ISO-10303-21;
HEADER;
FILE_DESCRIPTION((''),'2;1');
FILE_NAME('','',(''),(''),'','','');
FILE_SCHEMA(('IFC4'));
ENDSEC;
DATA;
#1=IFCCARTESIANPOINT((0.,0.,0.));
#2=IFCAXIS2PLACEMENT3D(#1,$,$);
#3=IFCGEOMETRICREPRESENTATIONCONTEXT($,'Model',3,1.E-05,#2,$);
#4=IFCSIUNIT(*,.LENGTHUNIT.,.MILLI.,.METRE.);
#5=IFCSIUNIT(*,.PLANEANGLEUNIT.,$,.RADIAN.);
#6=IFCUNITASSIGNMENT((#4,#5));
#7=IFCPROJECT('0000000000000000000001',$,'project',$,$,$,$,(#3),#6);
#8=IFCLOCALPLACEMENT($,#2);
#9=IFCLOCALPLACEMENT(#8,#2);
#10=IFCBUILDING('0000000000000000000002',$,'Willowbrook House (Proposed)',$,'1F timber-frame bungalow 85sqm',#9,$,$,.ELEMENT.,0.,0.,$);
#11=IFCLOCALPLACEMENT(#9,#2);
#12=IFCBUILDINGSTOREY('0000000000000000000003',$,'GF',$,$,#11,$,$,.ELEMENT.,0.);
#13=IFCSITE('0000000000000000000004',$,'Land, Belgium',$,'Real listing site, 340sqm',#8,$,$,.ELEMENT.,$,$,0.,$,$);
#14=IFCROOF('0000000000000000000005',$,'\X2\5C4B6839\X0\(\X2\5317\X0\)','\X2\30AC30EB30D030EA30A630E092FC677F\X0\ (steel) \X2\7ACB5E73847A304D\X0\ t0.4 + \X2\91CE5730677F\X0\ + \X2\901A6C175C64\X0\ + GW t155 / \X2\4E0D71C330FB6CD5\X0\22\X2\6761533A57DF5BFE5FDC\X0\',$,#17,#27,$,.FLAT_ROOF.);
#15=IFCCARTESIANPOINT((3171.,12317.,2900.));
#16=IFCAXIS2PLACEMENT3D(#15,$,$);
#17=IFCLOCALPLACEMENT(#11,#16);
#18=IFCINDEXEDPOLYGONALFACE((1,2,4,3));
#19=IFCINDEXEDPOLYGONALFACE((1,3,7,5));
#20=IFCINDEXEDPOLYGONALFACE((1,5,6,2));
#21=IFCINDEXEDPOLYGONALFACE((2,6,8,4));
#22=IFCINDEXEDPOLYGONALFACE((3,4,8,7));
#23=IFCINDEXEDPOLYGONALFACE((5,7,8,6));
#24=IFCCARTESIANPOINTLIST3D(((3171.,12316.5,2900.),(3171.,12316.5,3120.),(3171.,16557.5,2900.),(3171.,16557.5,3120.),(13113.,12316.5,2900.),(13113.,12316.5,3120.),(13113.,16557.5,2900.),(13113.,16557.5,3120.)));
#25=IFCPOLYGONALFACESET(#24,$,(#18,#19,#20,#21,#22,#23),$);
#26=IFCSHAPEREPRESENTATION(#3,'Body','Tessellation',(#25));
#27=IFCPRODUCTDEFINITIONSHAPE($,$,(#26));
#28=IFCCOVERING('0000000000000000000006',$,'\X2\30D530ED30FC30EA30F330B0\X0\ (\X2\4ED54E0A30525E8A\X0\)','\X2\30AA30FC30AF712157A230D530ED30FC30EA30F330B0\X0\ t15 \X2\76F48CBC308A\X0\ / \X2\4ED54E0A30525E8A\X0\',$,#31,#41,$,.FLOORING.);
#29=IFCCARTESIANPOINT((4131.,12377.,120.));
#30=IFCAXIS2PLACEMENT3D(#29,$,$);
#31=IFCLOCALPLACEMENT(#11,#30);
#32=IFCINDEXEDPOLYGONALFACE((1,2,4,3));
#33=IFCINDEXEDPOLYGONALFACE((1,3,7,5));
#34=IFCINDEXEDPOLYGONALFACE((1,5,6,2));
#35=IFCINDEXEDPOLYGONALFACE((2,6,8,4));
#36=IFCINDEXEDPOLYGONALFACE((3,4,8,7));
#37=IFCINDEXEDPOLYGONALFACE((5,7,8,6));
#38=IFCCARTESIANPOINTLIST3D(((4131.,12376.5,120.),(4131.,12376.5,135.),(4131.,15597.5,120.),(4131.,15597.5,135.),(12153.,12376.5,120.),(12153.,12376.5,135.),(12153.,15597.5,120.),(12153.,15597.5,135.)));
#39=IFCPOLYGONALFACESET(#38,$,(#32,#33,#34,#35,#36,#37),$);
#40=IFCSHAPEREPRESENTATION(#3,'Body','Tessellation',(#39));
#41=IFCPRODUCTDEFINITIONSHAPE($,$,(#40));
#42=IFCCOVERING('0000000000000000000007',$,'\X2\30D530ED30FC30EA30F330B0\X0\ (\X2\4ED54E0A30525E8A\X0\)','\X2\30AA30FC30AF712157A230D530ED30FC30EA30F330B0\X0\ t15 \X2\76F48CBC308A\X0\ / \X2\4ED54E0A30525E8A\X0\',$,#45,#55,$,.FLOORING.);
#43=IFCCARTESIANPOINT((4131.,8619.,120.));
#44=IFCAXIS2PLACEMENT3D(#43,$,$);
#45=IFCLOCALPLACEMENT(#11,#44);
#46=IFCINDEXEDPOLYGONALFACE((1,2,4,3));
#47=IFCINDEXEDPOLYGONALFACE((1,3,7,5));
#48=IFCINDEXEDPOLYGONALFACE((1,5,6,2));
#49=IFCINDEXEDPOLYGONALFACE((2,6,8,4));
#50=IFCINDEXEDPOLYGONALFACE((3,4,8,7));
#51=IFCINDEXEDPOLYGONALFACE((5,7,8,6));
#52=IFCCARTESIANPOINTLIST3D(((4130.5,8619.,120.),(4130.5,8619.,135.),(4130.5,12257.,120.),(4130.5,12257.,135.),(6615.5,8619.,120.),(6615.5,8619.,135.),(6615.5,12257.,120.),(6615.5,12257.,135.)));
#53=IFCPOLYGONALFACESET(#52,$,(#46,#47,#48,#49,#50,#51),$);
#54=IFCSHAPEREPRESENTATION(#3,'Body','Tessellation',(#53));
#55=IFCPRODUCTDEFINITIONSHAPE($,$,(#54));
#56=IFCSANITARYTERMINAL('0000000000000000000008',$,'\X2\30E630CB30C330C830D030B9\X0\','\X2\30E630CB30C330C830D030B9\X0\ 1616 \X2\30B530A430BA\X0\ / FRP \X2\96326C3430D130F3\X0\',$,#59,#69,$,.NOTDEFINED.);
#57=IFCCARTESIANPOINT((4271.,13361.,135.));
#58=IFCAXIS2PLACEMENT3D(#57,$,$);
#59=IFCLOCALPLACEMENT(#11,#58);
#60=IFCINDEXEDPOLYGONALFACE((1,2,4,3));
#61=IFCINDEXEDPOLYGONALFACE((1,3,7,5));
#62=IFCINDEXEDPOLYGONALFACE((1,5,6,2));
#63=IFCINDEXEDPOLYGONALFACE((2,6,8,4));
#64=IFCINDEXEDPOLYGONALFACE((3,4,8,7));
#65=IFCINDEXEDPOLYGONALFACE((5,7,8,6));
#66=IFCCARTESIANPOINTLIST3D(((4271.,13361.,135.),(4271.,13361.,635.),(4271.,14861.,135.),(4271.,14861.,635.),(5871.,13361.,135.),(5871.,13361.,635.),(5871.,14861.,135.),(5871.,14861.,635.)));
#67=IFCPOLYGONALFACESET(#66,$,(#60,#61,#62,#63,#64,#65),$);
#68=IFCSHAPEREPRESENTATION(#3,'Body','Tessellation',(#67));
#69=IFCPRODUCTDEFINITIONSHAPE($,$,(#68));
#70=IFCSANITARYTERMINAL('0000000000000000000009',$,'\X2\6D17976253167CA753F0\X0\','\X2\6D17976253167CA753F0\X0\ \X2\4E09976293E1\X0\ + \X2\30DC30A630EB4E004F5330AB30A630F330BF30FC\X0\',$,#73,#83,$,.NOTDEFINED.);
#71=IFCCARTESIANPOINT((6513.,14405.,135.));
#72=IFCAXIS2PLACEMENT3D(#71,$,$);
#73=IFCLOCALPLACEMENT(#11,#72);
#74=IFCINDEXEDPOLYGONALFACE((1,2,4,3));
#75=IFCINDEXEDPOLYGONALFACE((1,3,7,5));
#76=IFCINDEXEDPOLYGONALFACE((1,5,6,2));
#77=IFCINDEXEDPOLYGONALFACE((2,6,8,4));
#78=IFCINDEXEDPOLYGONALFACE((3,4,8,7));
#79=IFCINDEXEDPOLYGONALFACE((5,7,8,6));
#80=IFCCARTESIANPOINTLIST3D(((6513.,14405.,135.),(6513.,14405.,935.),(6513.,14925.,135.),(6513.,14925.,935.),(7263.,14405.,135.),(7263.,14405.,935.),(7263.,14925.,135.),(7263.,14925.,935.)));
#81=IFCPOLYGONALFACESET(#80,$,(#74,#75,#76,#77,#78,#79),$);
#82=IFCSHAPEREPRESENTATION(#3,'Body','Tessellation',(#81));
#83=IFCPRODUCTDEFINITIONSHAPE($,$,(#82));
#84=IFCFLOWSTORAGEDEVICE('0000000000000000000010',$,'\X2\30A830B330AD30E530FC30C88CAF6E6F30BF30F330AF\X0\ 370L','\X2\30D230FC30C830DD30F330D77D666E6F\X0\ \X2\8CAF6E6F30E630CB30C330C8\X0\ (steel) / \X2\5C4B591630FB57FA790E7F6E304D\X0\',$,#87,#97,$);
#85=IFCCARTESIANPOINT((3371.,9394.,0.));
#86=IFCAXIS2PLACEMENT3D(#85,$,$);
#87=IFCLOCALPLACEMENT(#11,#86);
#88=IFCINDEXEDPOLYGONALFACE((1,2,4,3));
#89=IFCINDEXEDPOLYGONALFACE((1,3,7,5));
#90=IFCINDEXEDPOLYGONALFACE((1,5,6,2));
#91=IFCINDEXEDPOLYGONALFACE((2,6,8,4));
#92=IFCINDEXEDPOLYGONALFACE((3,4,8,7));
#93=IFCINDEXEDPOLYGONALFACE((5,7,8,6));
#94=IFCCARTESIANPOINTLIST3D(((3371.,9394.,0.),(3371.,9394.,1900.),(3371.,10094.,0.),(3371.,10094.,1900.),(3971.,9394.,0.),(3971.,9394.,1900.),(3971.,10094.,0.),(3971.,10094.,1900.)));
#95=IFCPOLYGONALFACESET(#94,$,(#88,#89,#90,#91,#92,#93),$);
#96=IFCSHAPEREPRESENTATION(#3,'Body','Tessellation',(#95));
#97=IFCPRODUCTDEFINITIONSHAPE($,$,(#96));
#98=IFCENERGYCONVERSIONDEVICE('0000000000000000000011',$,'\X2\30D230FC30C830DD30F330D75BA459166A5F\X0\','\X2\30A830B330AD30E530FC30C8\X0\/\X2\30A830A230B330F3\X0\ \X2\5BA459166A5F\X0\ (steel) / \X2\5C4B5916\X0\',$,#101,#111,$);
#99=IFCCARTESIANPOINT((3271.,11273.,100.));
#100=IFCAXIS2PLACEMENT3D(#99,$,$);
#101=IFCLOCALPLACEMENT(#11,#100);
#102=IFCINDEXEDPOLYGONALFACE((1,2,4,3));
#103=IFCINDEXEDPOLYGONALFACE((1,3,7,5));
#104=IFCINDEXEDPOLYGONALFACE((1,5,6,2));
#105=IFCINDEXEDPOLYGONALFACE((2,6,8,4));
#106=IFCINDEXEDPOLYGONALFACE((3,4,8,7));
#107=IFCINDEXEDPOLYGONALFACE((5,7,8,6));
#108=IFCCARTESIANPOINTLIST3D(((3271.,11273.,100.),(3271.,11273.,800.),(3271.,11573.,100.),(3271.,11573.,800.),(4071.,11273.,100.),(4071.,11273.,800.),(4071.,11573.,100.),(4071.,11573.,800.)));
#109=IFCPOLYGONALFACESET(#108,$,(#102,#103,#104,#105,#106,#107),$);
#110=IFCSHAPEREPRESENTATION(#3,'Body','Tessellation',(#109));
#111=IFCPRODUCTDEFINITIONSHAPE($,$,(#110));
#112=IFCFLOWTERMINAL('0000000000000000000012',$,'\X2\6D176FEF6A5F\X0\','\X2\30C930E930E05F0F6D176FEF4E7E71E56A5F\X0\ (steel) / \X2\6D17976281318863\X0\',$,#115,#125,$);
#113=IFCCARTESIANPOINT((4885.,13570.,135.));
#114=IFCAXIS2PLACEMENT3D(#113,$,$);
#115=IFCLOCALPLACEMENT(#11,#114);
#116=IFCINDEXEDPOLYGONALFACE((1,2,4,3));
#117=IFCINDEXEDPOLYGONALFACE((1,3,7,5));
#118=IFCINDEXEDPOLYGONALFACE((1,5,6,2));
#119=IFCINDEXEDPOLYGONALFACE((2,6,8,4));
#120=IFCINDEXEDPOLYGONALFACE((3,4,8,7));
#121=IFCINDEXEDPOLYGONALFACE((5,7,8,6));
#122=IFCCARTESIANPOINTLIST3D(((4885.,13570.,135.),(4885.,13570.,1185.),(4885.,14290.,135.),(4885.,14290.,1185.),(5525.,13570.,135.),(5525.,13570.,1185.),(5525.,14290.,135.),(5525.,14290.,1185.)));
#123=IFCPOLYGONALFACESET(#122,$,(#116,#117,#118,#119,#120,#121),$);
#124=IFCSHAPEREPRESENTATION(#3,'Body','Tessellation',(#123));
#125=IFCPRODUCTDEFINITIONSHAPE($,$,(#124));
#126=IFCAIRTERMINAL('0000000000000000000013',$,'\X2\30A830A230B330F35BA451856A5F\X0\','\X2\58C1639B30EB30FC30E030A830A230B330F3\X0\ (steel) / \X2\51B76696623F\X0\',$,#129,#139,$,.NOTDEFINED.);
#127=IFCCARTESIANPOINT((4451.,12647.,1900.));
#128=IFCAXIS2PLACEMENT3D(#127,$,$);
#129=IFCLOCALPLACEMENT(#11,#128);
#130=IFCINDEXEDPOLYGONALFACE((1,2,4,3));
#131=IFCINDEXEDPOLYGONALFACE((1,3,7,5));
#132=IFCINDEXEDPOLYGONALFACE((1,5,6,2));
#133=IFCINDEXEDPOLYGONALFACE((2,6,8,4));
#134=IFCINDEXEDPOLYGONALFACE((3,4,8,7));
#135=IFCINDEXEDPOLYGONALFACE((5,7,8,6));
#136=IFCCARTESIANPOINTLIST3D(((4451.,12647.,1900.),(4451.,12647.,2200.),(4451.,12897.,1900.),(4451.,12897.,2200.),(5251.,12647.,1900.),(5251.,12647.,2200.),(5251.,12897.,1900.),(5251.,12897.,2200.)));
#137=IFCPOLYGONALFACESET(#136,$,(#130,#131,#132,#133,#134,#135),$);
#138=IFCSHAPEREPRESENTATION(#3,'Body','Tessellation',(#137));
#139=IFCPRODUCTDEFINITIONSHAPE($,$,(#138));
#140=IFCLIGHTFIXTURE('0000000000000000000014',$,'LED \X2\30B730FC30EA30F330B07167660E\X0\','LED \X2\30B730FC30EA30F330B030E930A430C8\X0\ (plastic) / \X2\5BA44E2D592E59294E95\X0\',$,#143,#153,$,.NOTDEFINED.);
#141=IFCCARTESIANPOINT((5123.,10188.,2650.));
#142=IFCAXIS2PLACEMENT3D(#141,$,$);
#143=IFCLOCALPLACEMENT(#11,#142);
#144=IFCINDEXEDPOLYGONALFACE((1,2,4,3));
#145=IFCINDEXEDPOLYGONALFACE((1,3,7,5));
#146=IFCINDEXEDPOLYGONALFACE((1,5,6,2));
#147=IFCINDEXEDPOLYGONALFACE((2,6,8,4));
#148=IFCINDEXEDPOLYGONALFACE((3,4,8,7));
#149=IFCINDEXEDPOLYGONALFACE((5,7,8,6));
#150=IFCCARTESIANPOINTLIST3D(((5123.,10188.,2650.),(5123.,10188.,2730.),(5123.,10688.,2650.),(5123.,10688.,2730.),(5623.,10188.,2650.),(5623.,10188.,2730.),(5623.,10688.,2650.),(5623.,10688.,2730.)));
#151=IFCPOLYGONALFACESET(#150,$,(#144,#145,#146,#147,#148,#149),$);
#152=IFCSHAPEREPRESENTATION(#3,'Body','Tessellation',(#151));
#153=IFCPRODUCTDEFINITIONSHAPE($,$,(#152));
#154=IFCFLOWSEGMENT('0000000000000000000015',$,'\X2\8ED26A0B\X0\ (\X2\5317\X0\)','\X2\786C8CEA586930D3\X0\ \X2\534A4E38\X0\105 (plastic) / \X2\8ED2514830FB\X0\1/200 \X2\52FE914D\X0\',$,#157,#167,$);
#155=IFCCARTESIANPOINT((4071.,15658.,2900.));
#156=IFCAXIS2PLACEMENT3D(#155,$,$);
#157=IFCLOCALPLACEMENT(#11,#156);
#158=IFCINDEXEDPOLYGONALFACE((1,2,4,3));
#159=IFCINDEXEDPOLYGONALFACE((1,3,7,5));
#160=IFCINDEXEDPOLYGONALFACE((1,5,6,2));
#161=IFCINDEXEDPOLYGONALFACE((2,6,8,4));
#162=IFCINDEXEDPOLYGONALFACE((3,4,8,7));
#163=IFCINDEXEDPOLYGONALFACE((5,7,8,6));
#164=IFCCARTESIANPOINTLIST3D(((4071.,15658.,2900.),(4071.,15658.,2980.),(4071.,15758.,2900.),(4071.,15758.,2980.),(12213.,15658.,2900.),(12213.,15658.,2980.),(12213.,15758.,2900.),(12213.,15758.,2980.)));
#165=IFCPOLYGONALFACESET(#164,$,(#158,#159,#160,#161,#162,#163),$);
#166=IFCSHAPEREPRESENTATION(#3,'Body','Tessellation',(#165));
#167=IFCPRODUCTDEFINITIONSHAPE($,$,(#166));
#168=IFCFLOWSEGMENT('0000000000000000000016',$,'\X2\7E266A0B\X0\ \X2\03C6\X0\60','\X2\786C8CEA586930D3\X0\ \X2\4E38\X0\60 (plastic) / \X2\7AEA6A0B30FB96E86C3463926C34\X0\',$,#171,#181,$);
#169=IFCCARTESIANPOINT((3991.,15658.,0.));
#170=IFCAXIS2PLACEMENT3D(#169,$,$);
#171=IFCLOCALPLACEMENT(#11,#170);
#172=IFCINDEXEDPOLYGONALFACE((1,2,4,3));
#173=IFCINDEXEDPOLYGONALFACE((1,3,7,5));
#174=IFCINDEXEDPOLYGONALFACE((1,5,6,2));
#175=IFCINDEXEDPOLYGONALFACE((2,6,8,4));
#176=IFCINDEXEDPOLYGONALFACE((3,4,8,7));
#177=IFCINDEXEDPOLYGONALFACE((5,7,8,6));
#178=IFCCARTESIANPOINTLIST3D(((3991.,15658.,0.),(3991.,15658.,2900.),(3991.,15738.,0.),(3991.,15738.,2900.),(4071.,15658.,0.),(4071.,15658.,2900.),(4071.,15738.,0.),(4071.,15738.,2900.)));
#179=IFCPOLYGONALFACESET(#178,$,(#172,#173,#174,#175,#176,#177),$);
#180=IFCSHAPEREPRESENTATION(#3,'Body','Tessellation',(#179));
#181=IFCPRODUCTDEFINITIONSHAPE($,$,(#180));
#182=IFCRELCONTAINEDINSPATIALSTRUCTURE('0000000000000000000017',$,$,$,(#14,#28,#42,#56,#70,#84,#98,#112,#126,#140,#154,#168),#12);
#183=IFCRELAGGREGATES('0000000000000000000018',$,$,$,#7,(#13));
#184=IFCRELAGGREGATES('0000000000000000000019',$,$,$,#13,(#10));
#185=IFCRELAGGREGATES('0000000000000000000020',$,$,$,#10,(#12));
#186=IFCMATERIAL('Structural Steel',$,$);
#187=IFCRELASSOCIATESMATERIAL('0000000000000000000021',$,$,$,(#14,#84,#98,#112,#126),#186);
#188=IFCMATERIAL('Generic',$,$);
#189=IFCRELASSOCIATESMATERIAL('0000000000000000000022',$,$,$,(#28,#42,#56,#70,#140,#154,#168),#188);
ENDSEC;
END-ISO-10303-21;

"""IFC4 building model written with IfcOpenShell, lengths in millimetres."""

from ifc_helpers import new_model, si_unit, frame, frame_2d, origin, place, context, project, spatial, rectangle, extrude, material, element, save


model = new_model("IFC4")

# Units and contexts
model_context = context("Model", 3, precision=1e-05, world=origin())
ifc_project = project(units=[si_unit("LENGTHUNIT", "METRE", prefix="MILLI"), si_unit("PLANEANGLEUNIT", "RADIAN")], contexts=[model_context])

# Site, building, storey
site_placement = place(None, origin())
site = spatial("IfcSite", under=ifc_project, at=site_placement, Name="Land, Belgium", ObjectType="Real listing site, 340sqm", CompositionType="ELEMENT", RefElevation=0.0)
building_placement = place(site_placement, origin())
building = spatial("IfcBuilding", under=site, at=building_placement, Name="Willowbrook House (Proposed)", ObjectType="1F timber-frame bungalow 85sqm", CompositionType="ELEMENT", ElevationOfRefHeight=0.0, ElevationOfTerrain=0.0)
storey_placement = place(building_placement, origin())
storey = spatial("IfcBuildingStorey", under=building, at=storey_placement, Name="GF", CompositionType="ELEMENT", Elevation=0.0)

# Roof
ifc_material_1 = material(Name="Structural Steel")
roof_placement = place(storey_placement, frame((3171.0, 12317.0, 2900.0)))
element("IfcRoof", 1, at=roof_placement, inside=storey, material=ifc_material_1, Name="屋根(北)", Description="ガルバリウム鋼板 (steel) 立平葺き t0.4 + 野地板 + 通気層 + GW t155 / 不燃・法22条区域対応", PredefinedType="FLAT_ROOF", context=model_context, shape_type="SweptSolid", body=[
    extrude(rectangle(XDim=9942.0, YDim=4241.0, at=frame_2d((4971.0, 2120.0))), frame((3171.0, 12317.0, 2900.0)), (0.0, 0.0, 1.0), 220.0),
])

# Coverings
ifc_material_2 = material(Name="Generic")
covering_1_placement = place(storey_placement, frame((4131.0, 12377.0, 120.0)))
element("IfcCovering", 2, at=covering_1_placement, inside=storey, material=ifc_material_2, Name="フローリング (仕上げ床)", Description="オーク無垢フローリング t15 直貼り / 仕上げ床", PredefinedType="FLOORING", context=model_context, shape_type="SweptSolid", body=[
    extrude(rectangle(XDim=8022.0, YDim=3221.0, at=frame_2d((4011.0, 1610.0))), frame((4131.0, 12377.0, 120.0)), (0.0, 0.0, 1.0), 15.0),
])
covering_2_placement = place(storey_placement, frame((4131.0, 8619.0, 120.0)))
element("IfcCovering", 3, at=covering_2_placement, inside=storey, material=ifc_material_2, Name="フローリング (仕上げ床)", Description="オーク無垢フローリング t15 直貼り / 仕上げ床", PredefinedType="FLOORING", context=model_context, shape_type="SweptSolid", body=[
    extrude(rectangle(XDim=2485.0, YDim=3638.0, at=frame_2d((1242.0, 1819.0))), frame((4131.0, 8619.0, 120.0)), (0.0, 0.0, 1.0), 15.0),
])

# Sanitary terminals
sanitary_terminal_1_placement = place(storey_placement, frame((4271.0, 13361.0, 135.0)))
element("IfcSanitaryTerminal", 4, at=sanitary_terminal_1_placement, inside=storey, material=ifc_material_2, Name="ユニットバス", Description="ユニットバス 1616 サイズ / FRP 防水パン", PredefinedType="NOTDEFINED", context=model_context, shape_type="SweptSolid", body=[
    extrude(rectangle(XDim=1600.0, YDim=1500.0, at=frame_2d((800.0, 750.0))), frame((4271.0, 13361.0, 135.0)), (0.0, 0.0, 1.0), 500.0),
])
sanitary_terminal_2_placement = place(storey_placement, frame((6513.0, 14405.0, 135.0)))
element("IfcSanitaryTerminal", 5, at=sanitary_terminal_2_placement, inside=storey, material=ifc_material_2, Name="洗面化粧台", Description="洗面化粧台 三面鏡 + ボウル一体カウンター", PredefinedType="NOTDEFINED", context=model_context, shape_type="SweptSolid", body=[
    extrude(rectangle(XDim=750.0, YDim=520.0, at=frame_2d((375.0, 260.0))), frame((6513.0, 14405.0, 135.0)), (0.0, 0.0, 1.0), 800.0),
])

# Flow storage device
flow_storage_device_placement = place(storey_placement, frame((3371.0, 9394.0, 0.0)))
element("IfcFlowStorageDevice", 6, at=flow_storage_device_placement, inside=storey, material=ifc_material_1, Name="エコキュート貯湯タンク 370L", Description="ヒートポンプ給湯 貯湯ユニット (steel) / 屋外・基礎置き", context=model_context, shape_type="SweptSolid", body=[
    extrude(rectangle(XDim=600.0, YDim=700.0, at=frame_2d((300.0, 350.0))), frame((3371.0, 9394.0, 0.0)), (0.0, 0.0, 1.0), 1900.0),
])

# Energy conversion device
energy_conversion_device_placement = place(storey_placement, frame((3271.0, 11273.0, 100.0)))
element("IfcEnergyConversionDevice", 7, at=energy_conversion_device_placement, inside=storey, material=ifc_material_1, Name="ヒートポンプ室外機", Description="エコキュート/エアコン 室外機 (steel) / 屋外", context=model_context, shape_type="SweptSolid", body=[
    extrude(rectangle(XDim=800.0, YDim=300.0, at=frame_2d((400.0, 150.0))), frame((3271.0, 11273.0, 100.0)), (0.0, 0.0, 1.0), 700.0),
])

# Flow terminal
flow_terminal_placement = place(storey_placement, frame((4885.0, 13570.0, 135.0)))
element("IfcFlowTerminal", 8, at=flow_terminal_placement, inside=storey, material=ifc_material_1, Name="洗濯機", Description="ドラム式洗濯乾燥機 (steel) / 洗面脱衣", context=model_context, shape_type="SweptSolid", body=[
    extrude(rectangle(XDim=640.0, YDim=720.0, at=frame_2d((320.0, 360.0))), frame((4885.0, 13570.0, 135.0)), (0.0, 0.0, 1.0), 1050.0),
])

# Air terminal
air_terminal_placement = place(storey_placement, frame((4451.0, 12647.0, 1900.0)))
element("IfcAirTerminal", 9, at=air_terminal_placement, inside=storey, material=ifc_material_1, Name="エアコン室内機", Description="壁掛ルームエアコン (steel) / 冷暖房", PredefinedType="NOTDEFINED", context=model_context, shape_type="SweptSolid", body=[
    extrude(rectangle(XDim=800.0, YDim=250.0, at=frame_2d((400.0, 125.0))), frame((4451.0, 12647.0, 1900.0)), (0.0, 0.0, 1.0), 300.0),
])

# Light fixture
light_fixture_placement = place(storey_placement, frame((5123.0, 10188.0, 2650.0)))
element("IfcLightFixture", 10, at=light_fixture_placement, inside=storey, material=ifc_material_2, Name="LED シーリング照明", Description="LED シーリングライト (plastic) / 室中央天井", PredefinedType="NOTDEFINED", context=model_context, shape_type="SweptSolid", body=[
    extrude(rectangle(XDim=500.0, YDim=500.0, at=frame_2d((250.0, 250.0))), frame((5123.0, 10188.0, 2650.0)), (0.0, 0.0, 1.0), 80.0),
])

# Flow segments
flow_segment_1_placement = place(storey_placement, frame((4071.0, 15658.0, 2900.0)))
element("IfcFlowSegment", 11, at=flow_segment_1_placement, inside=storey, material=ifc_material_2, Name="軒樋 (北)", Description="硬質塩ビ 半丸105 (plastic) / 軒先・1/200 勾配", context=model_context, shape_type="SweptSolid", body=[
    extrude(rectangle(XDim=8142.0, YDim=100.0, at=frame_2d((4071.0, 50.0))), frame((4071.0, 15658.0, 2900.0)), (0.0, 0.0, 1.0), 80.0),
])
flow_segment_2_placement = place(storey_placement, frame((3991.0, 15658.0, 0.0)))
element("IfcFlowSegment", 12, at=flow_segment_2_placement, inside=storey, material=ifc_material_2, Name="縦樋 φ60", Description="硬質塩ビ 丸60 (plastic) / 竪樋・雨水排水", context=model_context, shape_type="SweptSolid", body=[
    extrude(rectangle(XDim=80.0, YDim=80.0, at=frame_2d((40.0, 40.0))), frame((3991.0, 15658.0, 0.0)), (0.0, 0.0, 1.0), 2900.0),
])

save(model, "model.ifc")
